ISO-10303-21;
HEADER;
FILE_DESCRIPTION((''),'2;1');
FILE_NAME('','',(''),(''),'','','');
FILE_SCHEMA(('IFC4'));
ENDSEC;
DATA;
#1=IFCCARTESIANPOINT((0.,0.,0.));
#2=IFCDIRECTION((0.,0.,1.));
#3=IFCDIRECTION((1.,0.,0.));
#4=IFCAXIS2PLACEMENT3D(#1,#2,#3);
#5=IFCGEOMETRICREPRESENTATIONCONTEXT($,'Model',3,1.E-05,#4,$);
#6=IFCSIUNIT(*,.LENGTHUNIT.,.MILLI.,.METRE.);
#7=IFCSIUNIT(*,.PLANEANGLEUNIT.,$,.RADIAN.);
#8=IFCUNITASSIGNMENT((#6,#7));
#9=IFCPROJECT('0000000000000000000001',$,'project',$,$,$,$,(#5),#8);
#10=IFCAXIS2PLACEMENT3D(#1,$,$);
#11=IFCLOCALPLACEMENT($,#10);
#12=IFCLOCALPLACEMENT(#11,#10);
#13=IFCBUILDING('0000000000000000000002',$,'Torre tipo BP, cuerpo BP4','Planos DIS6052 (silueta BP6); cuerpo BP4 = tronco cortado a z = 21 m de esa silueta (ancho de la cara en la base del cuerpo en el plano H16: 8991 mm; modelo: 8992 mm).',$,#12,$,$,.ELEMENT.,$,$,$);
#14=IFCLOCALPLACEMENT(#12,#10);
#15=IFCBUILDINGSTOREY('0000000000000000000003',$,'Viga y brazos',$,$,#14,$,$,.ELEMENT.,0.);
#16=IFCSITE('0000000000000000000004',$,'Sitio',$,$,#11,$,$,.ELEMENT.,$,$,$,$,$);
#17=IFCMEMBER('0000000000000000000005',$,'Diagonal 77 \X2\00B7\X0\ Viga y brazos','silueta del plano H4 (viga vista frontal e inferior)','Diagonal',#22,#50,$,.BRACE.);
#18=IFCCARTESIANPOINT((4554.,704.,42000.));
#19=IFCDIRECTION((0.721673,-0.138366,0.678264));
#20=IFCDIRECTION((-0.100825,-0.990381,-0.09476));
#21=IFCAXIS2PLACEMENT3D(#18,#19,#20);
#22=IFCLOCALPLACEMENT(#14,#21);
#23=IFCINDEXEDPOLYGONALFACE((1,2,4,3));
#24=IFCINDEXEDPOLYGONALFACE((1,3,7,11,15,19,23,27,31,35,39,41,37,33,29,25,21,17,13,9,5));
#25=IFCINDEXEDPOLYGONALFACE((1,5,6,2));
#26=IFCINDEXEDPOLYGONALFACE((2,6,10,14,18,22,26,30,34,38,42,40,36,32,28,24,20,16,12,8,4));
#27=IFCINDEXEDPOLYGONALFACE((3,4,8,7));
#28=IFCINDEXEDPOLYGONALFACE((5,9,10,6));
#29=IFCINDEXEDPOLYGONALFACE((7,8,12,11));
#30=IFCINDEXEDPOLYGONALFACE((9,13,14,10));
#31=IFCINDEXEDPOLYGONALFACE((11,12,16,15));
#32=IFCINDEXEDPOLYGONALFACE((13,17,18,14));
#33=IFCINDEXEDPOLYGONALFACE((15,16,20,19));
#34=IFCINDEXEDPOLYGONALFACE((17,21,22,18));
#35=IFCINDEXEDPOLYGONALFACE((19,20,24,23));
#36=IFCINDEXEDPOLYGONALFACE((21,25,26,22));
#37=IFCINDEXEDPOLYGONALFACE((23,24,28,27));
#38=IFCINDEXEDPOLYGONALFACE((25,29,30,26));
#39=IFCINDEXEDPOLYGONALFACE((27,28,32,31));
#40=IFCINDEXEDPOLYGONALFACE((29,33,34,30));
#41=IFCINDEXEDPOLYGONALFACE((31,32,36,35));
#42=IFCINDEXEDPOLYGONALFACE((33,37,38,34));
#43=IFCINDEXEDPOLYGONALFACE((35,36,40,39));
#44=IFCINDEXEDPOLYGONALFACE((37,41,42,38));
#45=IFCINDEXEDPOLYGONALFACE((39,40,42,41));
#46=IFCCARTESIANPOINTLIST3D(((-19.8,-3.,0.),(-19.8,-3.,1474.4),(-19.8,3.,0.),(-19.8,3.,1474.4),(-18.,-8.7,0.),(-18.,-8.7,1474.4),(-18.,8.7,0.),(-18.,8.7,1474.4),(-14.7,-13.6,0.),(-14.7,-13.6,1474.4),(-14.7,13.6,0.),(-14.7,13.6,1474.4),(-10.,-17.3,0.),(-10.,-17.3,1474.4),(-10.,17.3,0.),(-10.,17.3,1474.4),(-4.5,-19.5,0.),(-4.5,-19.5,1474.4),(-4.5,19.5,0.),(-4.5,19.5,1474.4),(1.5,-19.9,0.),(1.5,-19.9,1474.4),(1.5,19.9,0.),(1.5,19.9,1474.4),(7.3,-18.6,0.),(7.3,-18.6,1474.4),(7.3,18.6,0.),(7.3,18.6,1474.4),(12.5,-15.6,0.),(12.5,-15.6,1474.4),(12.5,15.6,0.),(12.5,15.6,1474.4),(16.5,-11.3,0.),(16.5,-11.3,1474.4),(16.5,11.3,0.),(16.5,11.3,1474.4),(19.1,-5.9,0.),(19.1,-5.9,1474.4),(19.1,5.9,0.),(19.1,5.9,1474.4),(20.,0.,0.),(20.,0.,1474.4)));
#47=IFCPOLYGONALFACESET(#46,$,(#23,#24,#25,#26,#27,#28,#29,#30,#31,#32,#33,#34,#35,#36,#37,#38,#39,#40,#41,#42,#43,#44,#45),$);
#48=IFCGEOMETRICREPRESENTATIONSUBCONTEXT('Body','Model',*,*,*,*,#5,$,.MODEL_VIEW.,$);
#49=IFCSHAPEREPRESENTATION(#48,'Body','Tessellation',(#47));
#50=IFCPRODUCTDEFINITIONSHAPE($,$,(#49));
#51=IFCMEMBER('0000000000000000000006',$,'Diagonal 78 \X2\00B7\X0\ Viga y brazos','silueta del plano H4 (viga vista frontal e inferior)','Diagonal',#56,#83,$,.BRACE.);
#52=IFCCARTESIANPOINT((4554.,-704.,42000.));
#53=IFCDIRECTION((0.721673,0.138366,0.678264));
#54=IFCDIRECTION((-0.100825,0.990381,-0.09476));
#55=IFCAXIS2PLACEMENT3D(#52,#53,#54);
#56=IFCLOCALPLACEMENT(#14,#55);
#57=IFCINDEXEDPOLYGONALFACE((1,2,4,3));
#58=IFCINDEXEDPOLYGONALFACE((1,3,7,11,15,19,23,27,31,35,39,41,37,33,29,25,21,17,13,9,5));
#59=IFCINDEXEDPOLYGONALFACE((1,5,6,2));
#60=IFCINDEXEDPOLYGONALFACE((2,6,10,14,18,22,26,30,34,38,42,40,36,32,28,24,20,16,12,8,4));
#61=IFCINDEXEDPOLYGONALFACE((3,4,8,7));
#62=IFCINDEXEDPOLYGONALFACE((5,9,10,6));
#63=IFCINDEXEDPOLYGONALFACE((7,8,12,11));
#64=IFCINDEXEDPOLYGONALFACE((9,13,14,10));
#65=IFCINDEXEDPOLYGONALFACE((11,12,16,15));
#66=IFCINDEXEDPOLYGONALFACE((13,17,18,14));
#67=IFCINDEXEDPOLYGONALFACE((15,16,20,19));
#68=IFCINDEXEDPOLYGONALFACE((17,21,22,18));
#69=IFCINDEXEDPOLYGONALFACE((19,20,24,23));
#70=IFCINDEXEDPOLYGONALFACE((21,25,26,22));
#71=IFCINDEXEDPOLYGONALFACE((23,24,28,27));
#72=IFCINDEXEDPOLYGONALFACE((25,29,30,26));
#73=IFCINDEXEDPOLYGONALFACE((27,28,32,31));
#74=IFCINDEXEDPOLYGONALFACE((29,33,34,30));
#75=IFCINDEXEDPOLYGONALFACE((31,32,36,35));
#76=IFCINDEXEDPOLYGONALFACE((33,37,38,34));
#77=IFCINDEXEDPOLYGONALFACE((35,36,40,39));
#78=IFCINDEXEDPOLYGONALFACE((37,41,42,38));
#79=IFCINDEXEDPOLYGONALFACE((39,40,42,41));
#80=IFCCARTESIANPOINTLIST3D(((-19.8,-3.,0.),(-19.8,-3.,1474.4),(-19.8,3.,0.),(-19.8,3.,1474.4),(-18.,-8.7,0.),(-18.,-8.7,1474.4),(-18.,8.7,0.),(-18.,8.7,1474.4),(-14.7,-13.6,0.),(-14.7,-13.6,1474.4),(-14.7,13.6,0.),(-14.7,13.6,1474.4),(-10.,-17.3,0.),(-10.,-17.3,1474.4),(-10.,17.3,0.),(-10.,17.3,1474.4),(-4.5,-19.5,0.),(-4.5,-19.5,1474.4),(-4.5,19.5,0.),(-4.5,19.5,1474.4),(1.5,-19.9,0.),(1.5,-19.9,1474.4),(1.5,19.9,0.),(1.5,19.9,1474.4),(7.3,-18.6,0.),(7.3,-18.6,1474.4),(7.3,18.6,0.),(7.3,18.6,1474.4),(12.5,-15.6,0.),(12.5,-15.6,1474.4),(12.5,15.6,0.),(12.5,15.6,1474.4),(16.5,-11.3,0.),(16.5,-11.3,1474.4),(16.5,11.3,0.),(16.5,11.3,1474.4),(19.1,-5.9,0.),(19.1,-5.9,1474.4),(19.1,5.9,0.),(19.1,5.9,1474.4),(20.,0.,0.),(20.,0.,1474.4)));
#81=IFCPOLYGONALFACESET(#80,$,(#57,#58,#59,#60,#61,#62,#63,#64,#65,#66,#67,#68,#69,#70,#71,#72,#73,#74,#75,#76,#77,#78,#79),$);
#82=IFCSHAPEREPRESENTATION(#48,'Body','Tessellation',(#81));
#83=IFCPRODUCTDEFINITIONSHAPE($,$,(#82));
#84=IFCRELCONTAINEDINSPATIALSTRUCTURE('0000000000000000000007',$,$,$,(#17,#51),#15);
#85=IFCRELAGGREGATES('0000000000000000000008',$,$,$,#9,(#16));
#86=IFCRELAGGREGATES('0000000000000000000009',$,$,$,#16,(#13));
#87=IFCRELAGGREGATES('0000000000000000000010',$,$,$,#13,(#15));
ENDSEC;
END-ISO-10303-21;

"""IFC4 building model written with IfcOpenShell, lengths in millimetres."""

from ifc_helpers import new_model, si_unit, frame, origin, origin_with_axes, place, context, subcontext, project, spatial, circle, extrude, element, save


model = new_model("IFC4")

# Units and contexts
model_context = context("Model", 3, precision=1e-05, world=origin_with_axes())
body_context = subcontext(model_context, "Body", "Model", "MODEL_VIEW")
ifc_project = project(units=[si_unit("LENGTHUNIT", "METRE", prefix="MILLI"), si_unit("PLANEANGLEUNIT", "RADIAN")], contexts=[model_context])

# Site, building, storey
site_placement = place(None, origin())
site = spatial("IfcSite", under=ifc_project, at=site_placement, Name="Sitio", CompositionType="ELEMENT")
building_placement = place(site_placement, origin())
building = spatial("IfcBuilding", under=site, at=building_placement, Name="Torre tipo BP, cuerpo BP4", Description="Planos DIS6052 (silueta BP6); cuerpo BP4 = tronco cortado a z = 21 m de esa silueta (ancho de la cara en la base del cuerpo en el plano H16: 8991 mm; modelo: 8992 mm).", CompositionType="ELEMENT")
storey_placement = place(building_placement, origin())
storey = spatial("IfcBuildingStorey", under=building, at=storey_placement, Name="Viga y brazos", CompositionType="ELEMENT", Elevation=0.0)

# Members
for number, where, z_axis, x_axis, name in (
    (1, (4554.0, 704.0, 42000.0), (0.721673, -0.138366, 0.678264), (-0.100825, -0.990381, -0.09476), "Diagonal 77 · Viga y brazos"),
    (2, (4554.0, -704.0, 42000.0), (0.721673, 0.138366, 0.678264), (-0.100825, 0.990381, -0.09476), "Diagonal 78 · Viga y brazos"),
):
    element("IfcMember", number, at=place(storey_placement, frame(where, z_axis=z_axis, x_axis=x_axis)), inside=storey, Name=name, Description="silueta del plano H4 (viga vista frontal e inferior)", ObjectType="Diagonal", PredefinedType="BRACE", context=body_context, shape_type="SweptSolid", body=[
        extrude(circle(Radius=20.0), None, (0.0, 0.0, 1.0), 1474.4),
    ])

save(model, "model.ifc")
